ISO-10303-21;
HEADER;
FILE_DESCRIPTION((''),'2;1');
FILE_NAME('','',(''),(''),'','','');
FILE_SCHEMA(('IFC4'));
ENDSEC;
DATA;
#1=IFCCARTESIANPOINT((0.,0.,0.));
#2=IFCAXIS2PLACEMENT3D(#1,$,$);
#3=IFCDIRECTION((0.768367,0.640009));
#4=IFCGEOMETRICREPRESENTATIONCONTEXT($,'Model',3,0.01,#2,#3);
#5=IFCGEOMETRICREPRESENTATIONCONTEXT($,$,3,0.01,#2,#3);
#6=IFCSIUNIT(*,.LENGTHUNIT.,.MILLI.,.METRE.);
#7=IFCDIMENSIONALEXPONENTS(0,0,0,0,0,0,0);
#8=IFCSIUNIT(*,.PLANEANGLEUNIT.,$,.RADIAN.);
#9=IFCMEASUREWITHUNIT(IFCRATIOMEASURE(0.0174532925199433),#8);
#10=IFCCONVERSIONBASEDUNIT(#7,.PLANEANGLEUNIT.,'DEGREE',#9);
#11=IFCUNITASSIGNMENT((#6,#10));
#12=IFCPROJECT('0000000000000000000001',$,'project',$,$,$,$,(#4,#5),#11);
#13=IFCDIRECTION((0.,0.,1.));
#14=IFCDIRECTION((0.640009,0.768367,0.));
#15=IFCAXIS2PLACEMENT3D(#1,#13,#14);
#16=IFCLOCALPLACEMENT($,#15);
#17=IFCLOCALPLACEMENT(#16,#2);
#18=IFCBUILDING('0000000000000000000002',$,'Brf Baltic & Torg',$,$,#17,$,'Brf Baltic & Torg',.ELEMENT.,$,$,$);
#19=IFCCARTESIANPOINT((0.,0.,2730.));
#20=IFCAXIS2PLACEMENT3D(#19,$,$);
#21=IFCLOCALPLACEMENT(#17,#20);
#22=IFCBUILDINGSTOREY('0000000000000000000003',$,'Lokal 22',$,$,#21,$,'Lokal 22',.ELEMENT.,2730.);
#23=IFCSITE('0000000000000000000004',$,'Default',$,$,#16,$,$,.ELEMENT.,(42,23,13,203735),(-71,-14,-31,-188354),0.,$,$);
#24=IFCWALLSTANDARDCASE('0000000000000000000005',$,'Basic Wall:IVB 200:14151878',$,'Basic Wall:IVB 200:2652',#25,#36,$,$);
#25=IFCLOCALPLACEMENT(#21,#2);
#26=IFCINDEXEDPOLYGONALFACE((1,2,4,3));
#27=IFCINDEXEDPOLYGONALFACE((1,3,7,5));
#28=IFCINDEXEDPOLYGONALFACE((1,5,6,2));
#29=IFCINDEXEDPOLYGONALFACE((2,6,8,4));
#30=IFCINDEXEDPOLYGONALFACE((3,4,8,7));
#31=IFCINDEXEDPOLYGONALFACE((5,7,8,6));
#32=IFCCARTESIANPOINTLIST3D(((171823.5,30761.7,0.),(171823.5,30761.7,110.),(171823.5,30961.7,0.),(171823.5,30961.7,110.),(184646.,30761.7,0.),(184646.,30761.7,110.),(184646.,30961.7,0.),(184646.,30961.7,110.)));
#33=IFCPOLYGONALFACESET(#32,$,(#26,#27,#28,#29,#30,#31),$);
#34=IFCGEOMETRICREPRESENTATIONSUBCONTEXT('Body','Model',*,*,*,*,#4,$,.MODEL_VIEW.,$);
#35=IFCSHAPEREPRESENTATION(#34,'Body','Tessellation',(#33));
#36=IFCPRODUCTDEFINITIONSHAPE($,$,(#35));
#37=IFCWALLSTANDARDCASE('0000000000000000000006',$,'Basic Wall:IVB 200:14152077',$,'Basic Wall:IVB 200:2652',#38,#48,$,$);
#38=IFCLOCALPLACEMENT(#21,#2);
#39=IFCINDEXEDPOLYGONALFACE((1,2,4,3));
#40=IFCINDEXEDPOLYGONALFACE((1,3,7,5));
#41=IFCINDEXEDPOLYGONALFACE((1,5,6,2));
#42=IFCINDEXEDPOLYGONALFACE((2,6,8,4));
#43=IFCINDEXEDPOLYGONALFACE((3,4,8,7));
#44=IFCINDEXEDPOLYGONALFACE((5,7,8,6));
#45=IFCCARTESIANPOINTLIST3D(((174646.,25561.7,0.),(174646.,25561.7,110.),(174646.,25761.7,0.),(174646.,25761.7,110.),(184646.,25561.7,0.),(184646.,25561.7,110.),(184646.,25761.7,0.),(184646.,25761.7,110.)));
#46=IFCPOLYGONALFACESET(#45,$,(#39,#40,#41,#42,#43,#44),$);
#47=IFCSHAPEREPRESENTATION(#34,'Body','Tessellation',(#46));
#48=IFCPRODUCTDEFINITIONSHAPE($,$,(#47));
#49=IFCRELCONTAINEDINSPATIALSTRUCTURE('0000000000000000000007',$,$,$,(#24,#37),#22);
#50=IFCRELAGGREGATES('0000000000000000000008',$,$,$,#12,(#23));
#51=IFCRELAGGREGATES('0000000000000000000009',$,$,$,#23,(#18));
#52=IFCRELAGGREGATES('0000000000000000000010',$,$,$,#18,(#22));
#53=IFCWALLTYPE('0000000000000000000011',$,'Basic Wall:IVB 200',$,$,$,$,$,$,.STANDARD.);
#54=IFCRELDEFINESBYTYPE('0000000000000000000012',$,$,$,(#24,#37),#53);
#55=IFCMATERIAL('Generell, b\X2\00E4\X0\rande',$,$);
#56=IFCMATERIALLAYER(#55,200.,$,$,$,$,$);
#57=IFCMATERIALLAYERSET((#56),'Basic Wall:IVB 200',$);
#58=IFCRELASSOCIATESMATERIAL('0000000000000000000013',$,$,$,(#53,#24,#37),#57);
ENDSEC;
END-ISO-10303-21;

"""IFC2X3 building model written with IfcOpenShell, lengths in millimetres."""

from ifc_helpers import new_model, entity, si_unit, converted_unit, direction, frame, frame_2d, origin, place, context, subcontext, project, spatial, rectangle, extrude, clip, halfspace, material, layer, layer_set, layer_usage, type_object, element, save


model = new_model("IFC2X3")

# Units and contexts
model_context = context("Model", 3, precision=0.01, world=origin(), true_north=direction((0.768367, 0.640009)))
context_of_model = context(None, 3, precision=0.01, world=origin(), true_north=direction((0.768367, 0.640009)))
body_context = subcontext(model_context, "Body", "Model", "MODEL_VIEW")
ifc_project = project(units=[si_unit("LENGTHUNIT", "METRE", prefix="MILLI"), converted_unit("PLANEANGLEUNIT", "DEGREE", entity("IfcRatioMeasure", 0.0174532925199433), si_unit("PLANEANGLEUNIT", "RADIAN"), dimensions=[0, 0, 0, 0, 0, 0, 0])], contexts=[model_context, context_of_model])

# Site, building, storey
site_placement = place(None, frame((0.0, 0.0, 0.0), z_axis=(0.0, 0.0, 1.0), x_axis=(0.640009, 0.768367, 0.0)))
site = spatial("IfcSite", under=ifc_project, at=site_placement, Name="Default", CompositionType="ELEMENT", RefLatitude=(42, 23, 13, 203735), RefLongitude=(-71, -14, -31, -188354), RefElevation=0.0)
building_placement = place(site_placement, origin())
building = spatial("IfcBuilding", under=site, at=building_placement, Name="Brf Baltic & Torg", LongName="Brf Baltic & Torg", CompositionType="ELEMENT")
storey_placement = place(building_placement, frame((0.0, 0.0, 2730.0)))
storey = spatial("IfcBuildingStorey", under=building, at=storey_placement, Name="Lokal 22", LongName="Lokal 22", CompositionType="ELEMENT", Elevation=2730.0)

# Shared definitions
ifc_material = material(Name="Generell, bärande")
ifc_layer = layer(ifc_material, 200.0)
ifc_layer_set = layer_set([ifc_layer], Name="Basic Wall:IVB 200")
wall_type = type_object("IfcWallType", Name="Basic Wall:IVB 200", PredefinedType="STANDARD", material=ifc_layer_set)

# Wall
ifc_layer_usage_1 = layer_usage(ifc_layer_set, "AXIS2", "NEGATIVE", 100.0)
wall_1_placement = place(storey_placement, frame((184646.0, 30861.7, 0.0), z_axis=(0.0, 0.0, 1.0), x_axis=(-1.0, 0.0, 0.0)))
element("IfcWallStandardCase", 1, at=wall_1_placement, inside=storey, type_object=wall_type, material=ifc_layer_usage_1, Name="Basic Wall:IVB 200:14151878", ObjectType="Basic Wall:IVB 200:2652", context=body_context, shape_type="Clipping", body=[
    clip(extrude(rectangle(XDim=12822.5, YDim=200.0, at=frame_2d((6411.3, 0.0), x_axis=(-1.0, 0.0))), origin(), (0.0, 0.0, 1.0), 110.0), halfspace(frame((0.0, 0.0, -1080.0)), True)),
])

# Wall
ifc_layer_usage_2 = layer_usage(ifc_layer_set, "AXIS2", "NEGATIVE", 100.0)
wall_2_placement = place(storey_placement, frame((174646.0, 25661.7, 0.0)))
element("IfcWallStandardCase", 2, at=wall_2_placement, inside=storey, type_object=wall_type, material=ifc_layer_usage_2, Name="Basic Wall:IVB 200:14152077", ObjectType="Basic Wall:IVB 200:2652", context=body_context, shape_type="Clipping", body=[
    clip(extrude(rectangle(XDim=10000.0, YDim=200.0, at=frame_2d((5000.0, 0.0), x_axis=(-1.0, 0.0))), origin(), (0.0, 0.0, 1.0), 110.0), halfspace(frame((0.0, 0.0, -1080.0)), True)),
])

save(model, "model.ifc")
